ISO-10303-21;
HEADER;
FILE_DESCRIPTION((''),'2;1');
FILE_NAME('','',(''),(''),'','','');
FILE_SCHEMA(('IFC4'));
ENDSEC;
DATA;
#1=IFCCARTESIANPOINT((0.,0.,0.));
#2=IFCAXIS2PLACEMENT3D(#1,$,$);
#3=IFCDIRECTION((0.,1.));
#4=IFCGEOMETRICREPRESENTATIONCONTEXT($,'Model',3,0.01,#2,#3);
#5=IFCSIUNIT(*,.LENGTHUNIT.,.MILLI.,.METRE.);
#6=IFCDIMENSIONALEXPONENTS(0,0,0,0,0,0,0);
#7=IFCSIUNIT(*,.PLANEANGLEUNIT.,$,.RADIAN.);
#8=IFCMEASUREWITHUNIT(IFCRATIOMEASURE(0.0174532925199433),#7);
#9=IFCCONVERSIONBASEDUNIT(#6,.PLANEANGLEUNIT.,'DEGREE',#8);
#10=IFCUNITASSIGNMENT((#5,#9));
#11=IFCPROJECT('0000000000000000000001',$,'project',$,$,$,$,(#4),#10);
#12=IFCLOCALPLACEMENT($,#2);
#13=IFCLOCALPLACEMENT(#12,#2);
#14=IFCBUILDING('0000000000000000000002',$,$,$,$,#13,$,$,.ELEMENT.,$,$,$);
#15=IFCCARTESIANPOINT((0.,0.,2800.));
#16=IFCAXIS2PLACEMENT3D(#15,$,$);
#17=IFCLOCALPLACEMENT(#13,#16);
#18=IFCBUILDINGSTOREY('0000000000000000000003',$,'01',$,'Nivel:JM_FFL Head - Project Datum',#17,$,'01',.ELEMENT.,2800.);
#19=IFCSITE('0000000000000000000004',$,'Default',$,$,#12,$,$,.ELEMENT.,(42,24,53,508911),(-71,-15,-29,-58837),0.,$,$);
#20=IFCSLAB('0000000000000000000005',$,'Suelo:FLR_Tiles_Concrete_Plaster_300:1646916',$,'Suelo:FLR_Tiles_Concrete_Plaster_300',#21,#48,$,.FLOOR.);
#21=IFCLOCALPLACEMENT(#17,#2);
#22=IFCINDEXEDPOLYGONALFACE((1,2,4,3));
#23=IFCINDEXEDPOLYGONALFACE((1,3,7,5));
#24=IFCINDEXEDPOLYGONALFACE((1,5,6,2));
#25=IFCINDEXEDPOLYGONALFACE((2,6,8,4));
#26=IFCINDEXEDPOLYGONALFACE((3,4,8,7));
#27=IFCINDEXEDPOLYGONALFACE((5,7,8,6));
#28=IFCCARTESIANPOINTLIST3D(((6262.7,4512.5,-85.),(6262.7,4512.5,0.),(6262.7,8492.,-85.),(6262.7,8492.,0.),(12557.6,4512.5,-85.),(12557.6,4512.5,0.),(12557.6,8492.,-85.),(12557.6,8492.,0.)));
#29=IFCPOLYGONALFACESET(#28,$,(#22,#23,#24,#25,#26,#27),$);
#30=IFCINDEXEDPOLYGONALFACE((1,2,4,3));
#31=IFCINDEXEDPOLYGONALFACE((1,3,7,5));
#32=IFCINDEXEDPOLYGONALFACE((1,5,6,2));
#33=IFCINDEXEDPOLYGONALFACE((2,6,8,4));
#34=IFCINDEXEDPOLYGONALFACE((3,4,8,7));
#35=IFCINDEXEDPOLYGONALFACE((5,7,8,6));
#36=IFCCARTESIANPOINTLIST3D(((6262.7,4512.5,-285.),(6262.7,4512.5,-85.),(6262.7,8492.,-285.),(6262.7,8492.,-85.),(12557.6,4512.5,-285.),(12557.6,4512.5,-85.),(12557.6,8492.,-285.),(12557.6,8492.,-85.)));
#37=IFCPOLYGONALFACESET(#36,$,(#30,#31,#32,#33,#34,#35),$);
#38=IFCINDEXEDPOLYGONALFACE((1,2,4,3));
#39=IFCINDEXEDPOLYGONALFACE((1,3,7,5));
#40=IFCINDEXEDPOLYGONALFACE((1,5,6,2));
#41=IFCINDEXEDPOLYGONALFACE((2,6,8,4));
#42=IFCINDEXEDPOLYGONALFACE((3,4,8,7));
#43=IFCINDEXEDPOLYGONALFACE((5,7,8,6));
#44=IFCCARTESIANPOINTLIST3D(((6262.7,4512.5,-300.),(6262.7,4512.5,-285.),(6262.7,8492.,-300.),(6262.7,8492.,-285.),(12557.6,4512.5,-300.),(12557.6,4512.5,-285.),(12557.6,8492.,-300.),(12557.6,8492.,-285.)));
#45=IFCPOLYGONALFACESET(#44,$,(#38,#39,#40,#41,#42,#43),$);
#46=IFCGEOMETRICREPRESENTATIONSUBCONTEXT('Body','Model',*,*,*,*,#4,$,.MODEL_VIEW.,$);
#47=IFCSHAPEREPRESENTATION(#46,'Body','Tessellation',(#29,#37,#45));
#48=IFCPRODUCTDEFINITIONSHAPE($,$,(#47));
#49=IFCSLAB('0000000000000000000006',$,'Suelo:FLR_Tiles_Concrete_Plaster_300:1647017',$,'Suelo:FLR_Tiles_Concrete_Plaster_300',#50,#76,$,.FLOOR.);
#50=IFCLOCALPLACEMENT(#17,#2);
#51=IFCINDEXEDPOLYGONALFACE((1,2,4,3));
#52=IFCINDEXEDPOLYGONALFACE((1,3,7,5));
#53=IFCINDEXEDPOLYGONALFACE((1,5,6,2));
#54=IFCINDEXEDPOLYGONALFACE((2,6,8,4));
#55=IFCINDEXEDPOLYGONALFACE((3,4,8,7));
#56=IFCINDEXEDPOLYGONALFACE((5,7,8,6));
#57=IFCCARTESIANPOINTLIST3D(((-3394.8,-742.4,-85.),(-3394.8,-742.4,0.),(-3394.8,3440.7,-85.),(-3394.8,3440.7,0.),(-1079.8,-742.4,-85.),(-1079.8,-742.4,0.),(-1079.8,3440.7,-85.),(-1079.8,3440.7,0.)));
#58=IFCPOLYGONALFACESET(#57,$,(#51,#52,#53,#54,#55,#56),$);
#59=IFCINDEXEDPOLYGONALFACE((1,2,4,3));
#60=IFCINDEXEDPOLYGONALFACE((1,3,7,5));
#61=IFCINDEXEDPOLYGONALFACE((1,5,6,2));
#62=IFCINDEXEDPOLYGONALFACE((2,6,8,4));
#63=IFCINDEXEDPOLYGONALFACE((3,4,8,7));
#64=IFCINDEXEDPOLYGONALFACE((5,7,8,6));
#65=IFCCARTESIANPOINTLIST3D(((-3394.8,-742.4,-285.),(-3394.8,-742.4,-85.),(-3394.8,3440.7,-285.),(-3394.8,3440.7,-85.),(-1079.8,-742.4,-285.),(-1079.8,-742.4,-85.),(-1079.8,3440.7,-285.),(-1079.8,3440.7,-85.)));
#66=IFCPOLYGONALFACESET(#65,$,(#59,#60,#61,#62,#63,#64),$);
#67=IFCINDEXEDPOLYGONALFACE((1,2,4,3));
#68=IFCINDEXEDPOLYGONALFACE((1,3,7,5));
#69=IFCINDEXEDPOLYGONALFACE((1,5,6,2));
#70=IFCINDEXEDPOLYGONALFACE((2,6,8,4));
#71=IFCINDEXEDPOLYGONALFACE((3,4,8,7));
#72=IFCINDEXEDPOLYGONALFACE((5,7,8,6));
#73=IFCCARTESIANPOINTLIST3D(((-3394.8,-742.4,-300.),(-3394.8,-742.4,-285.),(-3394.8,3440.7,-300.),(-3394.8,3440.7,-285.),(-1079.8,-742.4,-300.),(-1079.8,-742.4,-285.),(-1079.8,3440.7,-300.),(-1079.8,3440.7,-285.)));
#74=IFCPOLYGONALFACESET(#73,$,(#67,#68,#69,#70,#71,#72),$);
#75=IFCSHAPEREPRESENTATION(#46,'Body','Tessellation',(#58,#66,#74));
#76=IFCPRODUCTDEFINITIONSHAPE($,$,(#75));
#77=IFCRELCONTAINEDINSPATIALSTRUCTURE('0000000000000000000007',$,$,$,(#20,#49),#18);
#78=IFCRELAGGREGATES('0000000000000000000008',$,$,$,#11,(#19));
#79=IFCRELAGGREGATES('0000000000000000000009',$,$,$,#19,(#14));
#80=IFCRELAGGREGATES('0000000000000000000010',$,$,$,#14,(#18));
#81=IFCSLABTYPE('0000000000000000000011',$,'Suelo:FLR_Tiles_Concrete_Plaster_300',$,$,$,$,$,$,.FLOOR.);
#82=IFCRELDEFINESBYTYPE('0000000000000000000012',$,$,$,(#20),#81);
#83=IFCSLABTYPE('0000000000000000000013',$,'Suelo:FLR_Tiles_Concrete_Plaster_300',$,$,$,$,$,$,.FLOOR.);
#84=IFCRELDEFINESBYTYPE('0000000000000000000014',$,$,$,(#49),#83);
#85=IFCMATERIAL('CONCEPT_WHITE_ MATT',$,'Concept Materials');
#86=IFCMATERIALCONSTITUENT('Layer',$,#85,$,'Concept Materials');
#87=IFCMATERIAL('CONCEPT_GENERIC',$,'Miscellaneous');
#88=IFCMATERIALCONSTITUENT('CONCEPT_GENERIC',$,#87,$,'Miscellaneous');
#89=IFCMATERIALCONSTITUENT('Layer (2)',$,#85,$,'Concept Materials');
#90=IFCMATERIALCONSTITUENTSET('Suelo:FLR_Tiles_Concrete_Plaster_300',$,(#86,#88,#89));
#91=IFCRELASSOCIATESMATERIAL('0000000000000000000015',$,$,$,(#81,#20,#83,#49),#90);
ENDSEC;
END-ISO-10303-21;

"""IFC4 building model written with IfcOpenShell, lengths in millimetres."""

from ifc_helpers import new_model, entity, si_unit, converted_unit, direction, frame, origin, place, context, subcontext, project, spatial, indexed_curve, outline, extrude, material, constituent, constituent_set, type_object, element, save


model = new_model("IFC4")

# Units and contexts
model_context = context("Model", 3, precision=0.01, world=origin(), true_north=direction((0.0, 1.0)))
body_context = subcontext(model_context, "Body", "Model", "MODEL_VIEW")
ifc_project = project(units=[si_unit("LENGTHUNIT", "METRE", prefix="MILLI"), converted_unit("PLANEANGLEUNIT", "DEGREE", entity("IfcRatioMeasure", 0.0174532925199433), si_unit("PLANEANGLEUNIT", "RADIAN"), dimensions=[0, 0, 0, 0, 0, 0, 0])], contexts=[model_context])

# Site, building, storey
site_placement = place(None, origin())
site = spatial("IfcSite", under=ifc_project, at=site_placement, Name="Default", CompositionType="ELEMENT", RefLatitude=(42, 24, 53, 508911), RefLongitude=(-71, -15, -29, -58837), RefElevation=0.0)
building_placement = place(site_placement, origin())
building = spatial("IfcBuilding", under=site, at=building_placement, CompositionType="ELEMENT")
storey_placement = place(building_placement, frame((0.0, 0.0, 2800.0)))
storey = spatial("IfcBuildingStorey", under=building, at=storey_placement, Name="01", ObjectType="Nivel:JM_FFL Head - Project Datum", LongName="01", CompositionType="ELEMENT", Elevation=2800.0)

# Slabs
ifc_material_1 = material(Name="CONCEPT_WHITE_ MATT", Category="Concept Materials")
ifc_constituent_1 = constituent(ifc_material_1, Name="Layer", Category="Concept Materials")
ifc_material_2 = material(Name="CONCEPT_GENERIC", Category="Miscellaneous")
ifc_constituent_2 = constituent(ifc_material_2, Name="CONCEPT_GENERIC", Category="Miscellaneous")
ifc_constituent_3 = constituent(ifc_material_1, Name="Layer (2)", Category="Concept Materials")
ifc_constituent_set = constituent_set(constituents=[ifc_constituent_1, ifc_constituent_2, ifc_constituent_3], Name="Suelo:FLR_Tiles_Concrete_Plaster_300")
slab_type_1 = type_object("IfcSlabType", Name="Suelo:FLR_Tiles_Concrete_Plaster_300", PredefinedType="FLOOR", material=ifc_constituent_set)
slab_1_placement = place(storey_placement, origin())
element("IfcSlab", 1, at=slab_1_placement, inside=storey, type_object=slab_type_1, material=ifc_constituent_set, Name="Suelo:FLR_Tiles_Concrete_Plaster_300:1646916", ObjectType="Suelo:FLR_Tiles_Concrete_Plaster_300", PredefinedType="FLOOR", context=body_context, shape_type="SweptSolid", body=[
    extrude(outline(indexed_curve([(-1989.7, -3147.4), (1989.7, -3147.4), (1989.7, 3147.4), (-1989.7, 3147.4), (-1989.7, -3147.4)], self_intersect=False)), frame((9410.2, 6502.2, -85.0), z_axis=(0.0, 0.0, 1.0), x_axis=(0.0, 1.0, 0.0)), (0.0, 0.0, 1.0), 85.0),
    extrude(outline(indexed_curve([(-1989.7, -3147.4), (1989.7, -3147.4), (1989.7, 3147.4), (-1989.7, 3147.4), (-1989.7, -3147.4)], self_intersect=False)), frame((9410.2, 6502.2, -285.0), z_axis=(0.0, 0.0, 1.0), x_axis=(0.0, 1.0, 0.0)), (0.0, 0.0, 1.0), 200.0),
    extrude(outline(indexed_curve([(-1989.7, -3147.4), (1989.7, -3147.4), (1989.7, 3147.4), (-1989.7, 3147.4), (-1989.7, -3147.4)], self_intersect=False)), frame((9410.2, 6502.2, -300.0), z_axis=(0.0, 0.0, 1.0), x_axis=(0.0, 1.0, 0.0)), (0.0, 0.0, 1.0), 15.0),
])
slab_type_2 = type_object("IfcSlabType", Name="Suelo:FLR_Tiles_Concrete_Plaster_300", PredefinedType="FLOOR", material=ifc_constituent_set)
slab_2_placement = place(storey_placement, origin())
element("IfcSlab", 2, at=slab_2_placement, inside=storey, type_object=slab_type_2, material=ifc_constituent_set, Name="Suelo:FLR_Tiles_Concrete_Plaster_300:1647017", ObjectType="Suelo:FLR_Tiles_Concrete_Plaster_300", PredefinedType="FLOOR", context=body_context, shape_type="SweptSolid", body=[
    extrude(outline(indexed_curve([(-1157.5, -2091.5), (1157.5, -2091.5), (1157.5, 2091.5), (-1157.5, 2091.5), (-1157.5, -2091.5)], self_intersect=False)), frame((-2237.3, 1349.2, -85.0), z_axis=(0.0, 0.0, 1.0), x_axis=(-1.0, 0.0, 0.0)), (0.0, 0.0, 1.0), 85.0),
    extrude(outline(indexed_curve([(-1157.5, -2091.5), (1157.5, -2091.5), (1157.5, 2091.5), (-1157.5, 2091.5), (-1157.5, -2091.5)], self_intersect=False)), frame((-2237.3, 1349.2, -285.0), z_axis=(0.0, 0.0, 1.0), x_axis=(-1.0, 0.0, 0.0)), (0.0, 0.0, 1.0), 200.0),
    extrude(outline(indexed_curve([(-2091.5, -1157.5), (2091.5, -1157.5), (2091.5, 1157.5), (-2091.5, 1157.5), (-2091.5, -1157.5)], self_intersect=False)), frame((-2237.3, 1349.2, -300.0), z_axis=(0.0, 0.0, 1.0), x_axis=(0.0, 1.0, 0.0)), (0.0, 0.0, 1.0), 15.0),
])

save(model, "model.ifc")
